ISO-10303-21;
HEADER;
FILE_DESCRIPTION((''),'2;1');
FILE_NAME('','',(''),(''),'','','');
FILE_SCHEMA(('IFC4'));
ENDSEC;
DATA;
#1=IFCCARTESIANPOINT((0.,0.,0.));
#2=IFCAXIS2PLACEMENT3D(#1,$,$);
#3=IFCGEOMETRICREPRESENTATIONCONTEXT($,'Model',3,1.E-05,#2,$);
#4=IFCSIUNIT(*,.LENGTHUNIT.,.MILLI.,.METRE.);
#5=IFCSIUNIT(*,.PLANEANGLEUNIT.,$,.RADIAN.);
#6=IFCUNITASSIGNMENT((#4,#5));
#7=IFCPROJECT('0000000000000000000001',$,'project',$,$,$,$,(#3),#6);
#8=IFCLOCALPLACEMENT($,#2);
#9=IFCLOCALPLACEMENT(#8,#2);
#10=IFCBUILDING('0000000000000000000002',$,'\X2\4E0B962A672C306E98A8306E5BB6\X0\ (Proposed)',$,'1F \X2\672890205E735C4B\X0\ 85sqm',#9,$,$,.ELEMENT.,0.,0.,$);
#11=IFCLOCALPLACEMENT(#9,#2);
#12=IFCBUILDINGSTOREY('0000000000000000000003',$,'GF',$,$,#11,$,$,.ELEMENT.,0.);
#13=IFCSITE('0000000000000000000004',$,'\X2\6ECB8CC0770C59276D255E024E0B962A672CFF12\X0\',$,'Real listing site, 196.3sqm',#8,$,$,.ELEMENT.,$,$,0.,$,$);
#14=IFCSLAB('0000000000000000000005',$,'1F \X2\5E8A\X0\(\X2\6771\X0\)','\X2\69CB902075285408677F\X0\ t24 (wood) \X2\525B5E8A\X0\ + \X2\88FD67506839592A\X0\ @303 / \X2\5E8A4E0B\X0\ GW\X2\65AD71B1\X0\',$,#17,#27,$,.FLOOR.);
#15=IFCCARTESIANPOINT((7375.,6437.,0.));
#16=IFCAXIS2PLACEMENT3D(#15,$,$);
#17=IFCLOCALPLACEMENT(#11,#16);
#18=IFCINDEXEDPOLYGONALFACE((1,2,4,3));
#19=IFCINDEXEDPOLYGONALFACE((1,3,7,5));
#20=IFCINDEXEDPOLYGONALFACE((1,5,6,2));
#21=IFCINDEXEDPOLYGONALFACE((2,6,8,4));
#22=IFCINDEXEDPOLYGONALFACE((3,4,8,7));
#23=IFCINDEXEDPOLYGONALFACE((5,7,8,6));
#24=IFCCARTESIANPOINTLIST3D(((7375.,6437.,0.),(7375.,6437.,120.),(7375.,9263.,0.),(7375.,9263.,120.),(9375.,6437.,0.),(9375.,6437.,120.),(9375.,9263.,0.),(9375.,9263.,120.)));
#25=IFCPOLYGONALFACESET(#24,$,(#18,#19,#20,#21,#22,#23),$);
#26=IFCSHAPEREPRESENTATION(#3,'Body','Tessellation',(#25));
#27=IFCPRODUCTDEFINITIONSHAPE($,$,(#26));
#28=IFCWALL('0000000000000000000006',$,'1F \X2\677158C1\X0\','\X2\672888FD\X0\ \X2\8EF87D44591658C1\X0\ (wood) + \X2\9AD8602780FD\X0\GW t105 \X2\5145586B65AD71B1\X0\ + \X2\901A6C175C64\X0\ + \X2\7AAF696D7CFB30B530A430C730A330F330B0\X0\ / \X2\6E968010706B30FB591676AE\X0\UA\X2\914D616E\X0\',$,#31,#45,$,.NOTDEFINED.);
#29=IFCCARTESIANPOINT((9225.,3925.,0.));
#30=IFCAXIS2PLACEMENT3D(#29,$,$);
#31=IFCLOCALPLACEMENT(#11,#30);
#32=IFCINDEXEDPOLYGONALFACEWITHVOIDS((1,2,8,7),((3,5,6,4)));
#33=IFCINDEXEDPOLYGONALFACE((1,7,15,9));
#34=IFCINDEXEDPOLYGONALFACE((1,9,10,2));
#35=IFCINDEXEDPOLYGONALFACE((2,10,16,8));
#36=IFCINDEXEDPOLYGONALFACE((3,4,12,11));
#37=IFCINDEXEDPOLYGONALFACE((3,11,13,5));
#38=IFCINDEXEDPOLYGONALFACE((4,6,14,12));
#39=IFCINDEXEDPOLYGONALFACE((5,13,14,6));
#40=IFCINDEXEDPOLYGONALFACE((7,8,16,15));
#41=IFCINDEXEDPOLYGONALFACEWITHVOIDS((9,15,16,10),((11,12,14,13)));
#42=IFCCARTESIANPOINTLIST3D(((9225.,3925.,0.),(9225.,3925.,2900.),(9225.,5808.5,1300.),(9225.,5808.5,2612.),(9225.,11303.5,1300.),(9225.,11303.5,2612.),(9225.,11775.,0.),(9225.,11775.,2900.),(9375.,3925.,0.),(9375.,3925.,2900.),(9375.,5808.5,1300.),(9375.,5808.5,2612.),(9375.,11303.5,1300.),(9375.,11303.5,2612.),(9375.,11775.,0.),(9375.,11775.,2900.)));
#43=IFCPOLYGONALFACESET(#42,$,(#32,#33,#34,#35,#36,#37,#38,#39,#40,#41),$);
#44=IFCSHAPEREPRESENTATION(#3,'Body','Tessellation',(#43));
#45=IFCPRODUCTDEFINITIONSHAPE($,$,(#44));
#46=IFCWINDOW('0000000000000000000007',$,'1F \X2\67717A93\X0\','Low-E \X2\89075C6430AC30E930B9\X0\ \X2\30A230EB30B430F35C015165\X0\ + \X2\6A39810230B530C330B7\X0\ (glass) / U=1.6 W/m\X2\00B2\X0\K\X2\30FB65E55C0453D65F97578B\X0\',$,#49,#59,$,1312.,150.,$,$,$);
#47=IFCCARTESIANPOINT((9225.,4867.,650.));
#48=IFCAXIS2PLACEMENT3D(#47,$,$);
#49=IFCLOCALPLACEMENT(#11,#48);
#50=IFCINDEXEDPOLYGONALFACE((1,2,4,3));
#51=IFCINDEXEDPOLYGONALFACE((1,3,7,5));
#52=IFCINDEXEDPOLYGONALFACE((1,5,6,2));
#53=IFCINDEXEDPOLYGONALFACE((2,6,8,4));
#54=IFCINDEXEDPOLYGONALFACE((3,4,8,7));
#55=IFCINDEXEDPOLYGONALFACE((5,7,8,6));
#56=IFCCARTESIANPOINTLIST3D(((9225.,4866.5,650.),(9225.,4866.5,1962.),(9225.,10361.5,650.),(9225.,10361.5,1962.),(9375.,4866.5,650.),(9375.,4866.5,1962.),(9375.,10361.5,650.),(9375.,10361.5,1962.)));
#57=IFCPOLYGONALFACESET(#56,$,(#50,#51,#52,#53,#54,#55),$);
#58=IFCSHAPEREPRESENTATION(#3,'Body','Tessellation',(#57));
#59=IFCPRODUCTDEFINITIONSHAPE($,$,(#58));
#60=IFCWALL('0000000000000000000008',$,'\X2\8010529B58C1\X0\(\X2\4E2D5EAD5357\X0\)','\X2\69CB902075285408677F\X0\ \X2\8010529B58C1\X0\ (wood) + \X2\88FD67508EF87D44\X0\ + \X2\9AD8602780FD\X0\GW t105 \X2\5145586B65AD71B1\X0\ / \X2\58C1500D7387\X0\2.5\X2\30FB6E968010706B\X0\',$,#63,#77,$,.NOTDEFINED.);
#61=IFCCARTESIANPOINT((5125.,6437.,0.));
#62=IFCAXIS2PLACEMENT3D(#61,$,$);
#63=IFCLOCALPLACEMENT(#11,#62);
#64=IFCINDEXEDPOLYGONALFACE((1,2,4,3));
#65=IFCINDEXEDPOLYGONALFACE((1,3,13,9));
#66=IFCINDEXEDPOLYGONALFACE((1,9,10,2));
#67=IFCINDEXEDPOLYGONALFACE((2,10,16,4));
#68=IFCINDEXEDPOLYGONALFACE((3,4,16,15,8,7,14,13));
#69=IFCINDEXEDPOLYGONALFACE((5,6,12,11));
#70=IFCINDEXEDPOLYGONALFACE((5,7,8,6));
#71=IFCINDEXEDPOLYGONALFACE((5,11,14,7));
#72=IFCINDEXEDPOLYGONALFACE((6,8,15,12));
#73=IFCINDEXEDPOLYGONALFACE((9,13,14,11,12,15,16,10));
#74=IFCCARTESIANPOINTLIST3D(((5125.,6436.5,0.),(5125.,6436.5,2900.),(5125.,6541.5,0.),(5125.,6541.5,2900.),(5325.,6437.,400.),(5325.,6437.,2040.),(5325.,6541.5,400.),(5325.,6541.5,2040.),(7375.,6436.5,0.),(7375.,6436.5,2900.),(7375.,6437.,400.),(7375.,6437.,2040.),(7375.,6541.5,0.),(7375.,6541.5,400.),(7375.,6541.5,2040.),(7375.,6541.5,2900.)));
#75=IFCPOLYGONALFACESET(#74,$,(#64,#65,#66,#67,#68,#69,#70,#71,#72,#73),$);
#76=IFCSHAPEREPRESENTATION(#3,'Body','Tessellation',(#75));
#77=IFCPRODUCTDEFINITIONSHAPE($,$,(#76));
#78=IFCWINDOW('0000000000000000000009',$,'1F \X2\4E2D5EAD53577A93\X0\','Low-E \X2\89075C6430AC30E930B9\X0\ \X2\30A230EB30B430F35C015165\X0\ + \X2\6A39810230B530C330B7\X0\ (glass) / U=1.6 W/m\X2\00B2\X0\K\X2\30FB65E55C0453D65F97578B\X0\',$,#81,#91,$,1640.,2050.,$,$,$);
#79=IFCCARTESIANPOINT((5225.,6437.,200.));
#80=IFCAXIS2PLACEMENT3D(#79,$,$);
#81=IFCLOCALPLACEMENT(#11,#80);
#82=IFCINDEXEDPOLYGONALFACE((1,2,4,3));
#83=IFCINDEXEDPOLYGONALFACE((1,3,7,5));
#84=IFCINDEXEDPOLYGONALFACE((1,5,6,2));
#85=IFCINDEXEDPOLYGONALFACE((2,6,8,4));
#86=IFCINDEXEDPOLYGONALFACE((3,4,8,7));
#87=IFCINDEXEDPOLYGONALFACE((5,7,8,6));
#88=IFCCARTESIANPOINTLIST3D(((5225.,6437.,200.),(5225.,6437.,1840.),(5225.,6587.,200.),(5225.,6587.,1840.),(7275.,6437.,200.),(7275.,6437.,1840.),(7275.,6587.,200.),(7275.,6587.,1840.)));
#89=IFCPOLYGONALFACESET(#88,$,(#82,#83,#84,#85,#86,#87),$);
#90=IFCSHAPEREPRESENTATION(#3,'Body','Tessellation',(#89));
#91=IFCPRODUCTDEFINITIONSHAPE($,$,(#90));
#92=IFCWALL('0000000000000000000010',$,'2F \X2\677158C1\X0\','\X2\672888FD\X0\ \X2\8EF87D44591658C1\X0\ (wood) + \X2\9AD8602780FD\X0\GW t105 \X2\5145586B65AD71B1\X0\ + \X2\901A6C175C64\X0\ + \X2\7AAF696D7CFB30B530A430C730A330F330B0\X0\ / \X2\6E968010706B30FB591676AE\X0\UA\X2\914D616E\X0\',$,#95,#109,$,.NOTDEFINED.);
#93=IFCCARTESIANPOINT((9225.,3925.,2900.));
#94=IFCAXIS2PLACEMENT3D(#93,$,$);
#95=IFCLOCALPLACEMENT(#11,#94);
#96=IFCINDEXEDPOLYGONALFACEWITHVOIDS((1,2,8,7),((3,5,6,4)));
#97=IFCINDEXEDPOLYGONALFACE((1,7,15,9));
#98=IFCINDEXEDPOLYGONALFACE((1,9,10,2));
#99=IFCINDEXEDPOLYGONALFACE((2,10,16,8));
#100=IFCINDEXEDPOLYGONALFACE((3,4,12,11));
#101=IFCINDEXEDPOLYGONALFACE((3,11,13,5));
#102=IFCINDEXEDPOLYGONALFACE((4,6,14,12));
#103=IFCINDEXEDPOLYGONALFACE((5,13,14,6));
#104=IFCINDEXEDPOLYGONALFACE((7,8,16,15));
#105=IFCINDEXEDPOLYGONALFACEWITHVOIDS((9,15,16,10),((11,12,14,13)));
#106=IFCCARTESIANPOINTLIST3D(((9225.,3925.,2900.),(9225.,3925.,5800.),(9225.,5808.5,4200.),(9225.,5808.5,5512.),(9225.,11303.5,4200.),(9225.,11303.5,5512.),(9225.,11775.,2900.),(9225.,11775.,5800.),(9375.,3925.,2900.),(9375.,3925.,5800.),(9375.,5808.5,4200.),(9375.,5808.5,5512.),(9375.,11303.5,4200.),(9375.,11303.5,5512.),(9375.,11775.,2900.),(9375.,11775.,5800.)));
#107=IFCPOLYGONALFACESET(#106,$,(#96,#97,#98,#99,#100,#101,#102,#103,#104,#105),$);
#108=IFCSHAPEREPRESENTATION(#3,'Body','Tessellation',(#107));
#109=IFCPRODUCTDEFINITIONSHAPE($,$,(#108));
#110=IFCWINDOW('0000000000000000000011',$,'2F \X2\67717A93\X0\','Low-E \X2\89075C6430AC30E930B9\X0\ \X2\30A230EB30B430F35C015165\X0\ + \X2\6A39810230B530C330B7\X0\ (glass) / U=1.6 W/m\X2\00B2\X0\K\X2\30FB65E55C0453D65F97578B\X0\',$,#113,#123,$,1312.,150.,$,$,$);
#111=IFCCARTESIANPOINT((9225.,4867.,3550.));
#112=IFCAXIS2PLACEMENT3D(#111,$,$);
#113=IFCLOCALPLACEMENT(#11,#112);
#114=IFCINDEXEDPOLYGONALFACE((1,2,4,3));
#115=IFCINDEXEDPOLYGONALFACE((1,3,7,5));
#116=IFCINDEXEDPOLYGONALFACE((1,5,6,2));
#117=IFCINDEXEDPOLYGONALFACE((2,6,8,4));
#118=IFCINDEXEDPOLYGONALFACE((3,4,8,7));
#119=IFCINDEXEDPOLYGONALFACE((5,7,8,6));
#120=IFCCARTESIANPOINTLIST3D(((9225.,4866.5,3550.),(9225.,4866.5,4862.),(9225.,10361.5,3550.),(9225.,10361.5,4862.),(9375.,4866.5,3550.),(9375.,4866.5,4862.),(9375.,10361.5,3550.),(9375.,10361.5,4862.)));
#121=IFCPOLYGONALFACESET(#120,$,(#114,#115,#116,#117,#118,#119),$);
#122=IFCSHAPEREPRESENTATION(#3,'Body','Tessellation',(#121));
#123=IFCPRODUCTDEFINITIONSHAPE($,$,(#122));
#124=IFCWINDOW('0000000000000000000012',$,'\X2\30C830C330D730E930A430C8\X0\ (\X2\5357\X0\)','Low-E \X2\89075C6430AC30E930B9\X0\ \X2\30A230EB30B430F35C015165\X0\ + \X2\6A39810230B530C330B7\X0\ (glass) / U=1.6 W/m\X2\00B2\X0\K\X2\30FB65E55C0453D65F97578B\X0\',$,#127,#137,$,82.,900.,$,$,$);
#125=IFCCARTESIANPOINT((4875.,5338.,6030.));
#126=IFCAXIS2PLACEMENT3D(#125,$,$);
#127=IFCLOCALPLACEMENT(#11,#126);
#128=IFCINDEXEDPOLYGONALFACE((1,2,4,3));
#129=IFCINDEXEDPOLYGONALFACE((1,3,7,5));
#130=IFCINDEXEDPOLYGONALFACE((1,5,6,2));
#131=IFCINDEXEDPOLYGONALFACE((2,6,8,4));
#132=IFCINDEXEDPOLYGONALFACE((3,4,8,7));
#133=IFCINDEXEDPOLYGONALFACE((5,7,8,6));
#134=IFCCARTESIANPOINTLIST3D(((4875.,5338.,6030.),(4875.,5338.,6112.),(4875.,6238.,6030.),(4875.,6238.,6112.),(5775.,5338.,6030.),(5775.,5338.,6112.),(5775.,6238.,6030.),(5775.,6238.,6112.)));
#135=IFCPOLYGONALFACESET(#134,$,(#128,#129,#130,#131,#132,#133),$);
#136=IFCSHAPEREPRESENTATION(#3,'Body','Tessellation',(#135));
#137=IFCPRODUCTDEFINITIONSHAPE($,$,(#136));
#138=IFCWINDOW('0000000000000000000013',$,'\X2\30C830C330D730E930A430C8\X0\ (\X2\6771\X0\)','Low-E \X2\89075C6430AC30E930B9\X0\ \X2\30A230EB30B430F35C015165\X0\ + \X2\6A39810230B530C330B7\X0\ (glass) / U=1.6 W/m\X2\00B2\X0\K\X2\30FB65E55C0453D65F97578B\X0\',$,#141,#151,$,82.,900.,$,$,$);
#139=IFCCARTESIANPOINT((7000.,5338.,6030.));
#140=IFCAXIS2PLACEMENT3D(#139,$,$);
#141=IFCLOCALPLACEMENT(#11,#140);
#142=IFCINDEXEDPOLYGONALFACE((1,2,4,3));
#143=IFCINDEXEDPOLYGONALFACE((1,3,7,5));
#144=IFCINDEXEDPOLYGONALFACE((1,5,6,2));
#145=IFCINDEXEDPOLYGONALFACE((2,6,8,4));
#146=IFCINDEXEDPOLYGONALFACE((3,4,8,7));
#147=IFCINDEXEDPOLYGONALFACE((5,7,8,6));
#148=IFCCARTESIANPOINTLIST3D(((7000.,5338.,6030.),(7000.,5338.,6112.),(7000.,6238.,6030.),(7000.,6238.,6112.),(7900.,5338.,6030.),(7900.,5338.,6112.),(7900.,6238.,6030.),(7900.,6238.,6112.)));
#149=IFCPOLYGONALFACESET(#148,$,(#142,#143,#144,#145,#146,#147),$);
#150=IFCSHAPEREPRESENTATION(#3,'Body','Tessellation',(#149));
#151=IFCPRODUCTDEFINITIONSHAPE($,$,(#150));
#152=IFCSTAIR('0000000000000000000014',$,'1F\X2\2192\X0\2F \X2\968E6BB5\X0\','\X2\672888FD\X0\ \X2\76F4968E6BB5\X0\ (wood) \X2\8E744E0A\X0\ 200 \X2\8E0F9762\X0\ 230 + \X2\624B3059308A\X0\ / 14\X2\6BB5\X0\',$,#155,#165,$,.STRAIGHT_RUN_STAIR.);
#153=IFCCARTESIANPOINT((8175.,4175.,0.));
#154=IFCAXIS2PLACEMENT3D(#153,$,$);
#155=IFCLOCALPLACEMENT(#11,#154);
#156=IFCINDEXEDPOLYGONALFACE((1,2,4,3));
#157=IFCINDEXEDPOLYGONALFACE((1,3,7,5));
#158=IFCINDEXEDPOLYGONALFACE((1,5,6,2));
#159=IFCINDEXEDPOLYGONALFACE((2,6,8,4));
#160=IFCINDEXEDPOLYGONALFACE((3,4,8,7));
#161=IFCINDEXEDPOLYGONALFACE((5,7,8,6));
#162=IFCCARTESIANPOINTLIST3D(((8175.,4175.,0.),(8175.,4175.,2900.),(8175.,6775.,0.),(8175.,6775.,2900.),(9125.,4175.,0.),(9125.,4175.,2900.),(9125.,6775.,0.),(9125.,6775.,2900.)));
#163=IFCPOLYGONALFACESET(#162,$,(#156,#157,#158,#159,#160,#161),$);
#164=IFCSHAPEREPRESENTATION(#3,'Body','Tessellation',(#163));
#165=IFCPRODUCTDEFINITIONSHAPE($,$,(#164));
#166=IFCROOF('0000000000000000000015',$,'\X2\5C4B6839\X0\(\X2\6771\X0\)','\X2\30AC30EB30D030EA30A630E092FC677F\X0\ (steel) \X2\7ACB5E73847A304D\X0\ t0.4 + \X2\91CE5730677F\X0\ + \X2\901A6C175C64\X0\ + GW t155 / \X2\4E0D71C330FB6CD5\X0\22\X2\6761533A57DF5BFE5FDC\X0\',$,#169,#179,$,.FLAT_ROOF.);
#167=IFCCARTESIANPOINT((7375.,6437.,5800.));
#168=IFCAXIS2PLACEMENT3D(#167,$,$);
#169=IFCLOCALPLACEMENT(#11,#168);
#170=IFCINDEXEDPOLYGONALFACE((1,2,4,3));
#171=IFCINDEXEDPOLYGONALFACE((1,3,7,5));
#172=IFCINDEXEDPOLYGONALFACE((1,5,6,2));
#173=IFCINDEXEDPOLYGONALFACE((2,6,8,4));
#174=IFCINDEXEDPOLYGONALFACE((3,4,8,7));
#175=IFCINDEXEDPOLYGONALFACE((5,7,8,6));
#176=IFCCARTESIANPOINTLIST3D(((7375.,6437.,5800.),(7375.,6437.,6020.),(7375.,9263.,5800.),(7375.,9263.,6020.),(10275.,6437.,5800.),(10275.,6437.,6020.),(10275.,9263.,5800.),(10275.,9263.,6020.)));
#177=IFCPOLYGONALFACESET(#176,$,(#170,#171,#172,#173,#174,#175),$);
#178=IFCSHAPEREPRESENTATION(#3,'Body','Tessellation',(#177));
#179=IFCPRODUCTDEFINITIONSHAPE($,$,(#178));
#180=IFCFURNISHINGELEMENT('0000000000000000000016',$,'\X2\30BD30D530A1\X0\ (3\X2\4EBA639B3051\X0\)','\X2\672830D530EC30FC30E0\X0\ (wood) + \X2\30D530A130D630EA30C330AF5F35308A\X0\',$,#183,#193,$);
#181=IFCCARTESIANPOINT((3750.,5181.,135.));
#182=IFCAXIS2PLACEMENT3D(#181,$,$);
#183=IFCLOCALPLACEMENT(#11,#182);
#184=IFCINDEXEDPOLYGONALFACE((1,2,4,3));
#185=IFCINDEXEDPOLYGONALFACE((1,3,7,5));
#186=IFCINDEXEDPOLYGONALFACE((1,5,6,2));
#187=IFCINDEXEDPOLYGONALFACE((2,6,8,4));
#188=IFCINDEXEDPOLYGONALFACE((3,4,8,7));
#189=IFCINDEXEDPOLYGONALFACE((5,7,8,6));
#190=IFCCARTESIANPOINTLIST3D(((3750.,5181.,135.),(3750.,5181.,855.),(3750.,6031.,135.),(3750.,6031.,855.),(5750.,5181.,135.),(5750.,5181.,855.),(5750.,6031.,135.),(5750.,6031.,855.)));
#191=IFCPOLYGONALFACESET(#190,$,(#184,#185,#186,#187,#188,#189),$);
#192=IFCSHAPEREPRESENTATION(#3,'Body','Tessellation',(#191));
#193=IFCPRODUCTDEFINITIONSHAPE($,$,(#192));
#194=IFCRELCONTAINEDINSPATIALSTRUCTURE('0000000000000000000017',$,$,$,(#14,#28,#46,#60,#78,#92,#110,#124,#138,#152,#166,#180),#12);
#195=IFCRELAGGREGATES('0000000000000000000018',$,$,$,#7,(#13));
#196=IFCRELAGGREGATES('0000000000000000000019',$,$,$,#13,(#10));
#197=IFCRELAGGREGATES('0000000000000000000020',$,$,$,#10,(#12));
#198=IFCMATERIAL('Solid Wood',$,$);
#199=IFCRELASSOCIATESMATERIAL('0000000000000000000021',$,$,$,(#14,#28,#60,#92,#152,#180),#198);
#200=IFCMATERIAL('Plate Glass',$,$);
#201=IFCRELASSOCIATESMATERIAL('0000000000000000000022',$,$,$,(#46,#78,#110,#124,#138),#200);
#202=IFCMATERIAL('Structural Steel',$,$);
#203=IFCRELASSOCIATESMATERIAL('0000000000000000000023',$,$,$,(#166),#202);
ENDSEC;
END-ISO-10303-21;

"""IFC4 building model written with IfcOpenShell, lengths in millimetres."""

from ifc_helpers import new_model, si_unit, frame, frame_2d, origin, place, context, project, spatial, rectangle, extrude, material, element, fill, save


model = new_model("IFC4")

# Units and contexts
model_context = context("Model", 3, precision=1e-05, world=origin())
ifc_project = project(units=[si_unit("LENGTHUNIT", "METRE", prefix="MILLI"), si_unit("PLANEANGLEUNIT", "RADIAN")], contexts=[model_context])

# Site, building, storey
site_placement = place(None, origin())
site = spatial("IfcSite", under=ifc_project, at=site_placement, Name="滋賀県大津市下阪本２", ObjectType="Real listing site, 196.3sqm", CompositionType="ELEMENT", RefElevation=0.0)
building_placement = place(site_placement, origin())
building = spatial("IfcBuilding", under=site, at=building_placement, Name="下阪本の風の家 (Proposed)", ObjectType="1F 木造平屋 85sqm", CompositionType="ELEMENT", ElevationOfRefHeight=0.0, ElevationOfTerrain=0.0)
storey_placement = place(building_placement, origin())
storey = spatial("IfcBuildingStorey", under=building, at=storey_placement, Name="GF", CompositionType="ELEMENT", Elevation=0.0)

# Slab
ifc_material_1 = material(Name="Solid Wood")
slab_placement = place(storey_placement, frame((7375.0, 6437.0, 0.0)))
element("IfcSlab", 1, at=slab_placement, inside=storey, material=ifc_material_1, Name="1F 床(東)", Description="構造用合板 t24 (wood) 剛床 + 製材根太 @303 / 床下 GW断熱", PredefinedType="FLOOR", context=model_context, shape_type="SweptSolid", body=[
    extrude(rectangle(XDim=2000.0, YDim=2826.0, at=frame_2d((1000.0, 1413.0))), frame((7375.0, 6437.0, 0.0)), (0.0, 0.0, 1.0), 120.0),
])

# Walls, openings, windows
wall_1_placement = place(storey_placement, frame((9225.0, 3925.0, 0.0)))
wall_1 = element("IfcWall", 2, at=wall_1_placement, inside=storey, material=ifc_material_1, Name="1F 東壁", Description="木製 軸組外壁 (wood) + 高性能GW t105 充填断熱 + 通気層 + 窯業系サイディング / 準耐火・外皮UA配慮", PredefinedType="NOTDEFINED", context=model_context, shape_type="SweptSolid", body=[
    extrude(rectangle(XDim=150.0, YDim=7850.0, at=frame_2d((75.0, 3925.0))), frame((9225.0, 3925.0, 0.0)), (0.0, 0.0, 1.0), 2900.0),
])
opening_1_placement = place(storey_placement, frame((9225.0, 4867.0, 650.0)))
opening_1 = element("IfcOpeningElement", 3, at=opening_1_placement, cuts=wall_1, PredefinedType="NOTDEFINED", context=model_context, shape_type="SweptSolid", body=[
    extrude(rectangle(XDim=150.0, YDim=5495.0, at=frame_2d((75.0, 2747.0))), frame((9225.0, 4867.0, 650.0)), (0.0, 0.0, 1.0), 1312.0),
])
ifc_material_2 = material(Name="Plate Glass")
window_1_placement = place(storey_placement, frame((9225.0, 4867.0, 650.0)))
window_1 = element("IfcWindow", 4, at=window_1_placement, inside=storey, material=ifc_material_2, Name="1F 東窓", Description="Low-E 複層ガラス アルゴン封入 + 樹脂サッシ (glass) / U=1.6 W/m²K・日射取得型", OverallHeight=1312.0, OverallWidth=150.0, context=model_context, shape_type="SweptSolid", body=[
    extrude(rectangle(XDim=150.0, YDim=5495.0, at=frame_2d((75.0, 2747.0))), frame((9225.0, 4867.0, 650.0)), (0.0, 0.0, 1.0), 1312.0),
])
fill(opening_1, window_1)
wall_2_placement = place(storey_placement, frame((5125.0, 6437.0, 0.0)))
wall_2 = element("IfcWall", 5, at=wall_2_placement, inside=storey, material=ifc_material_1, Name="耐力壁(中庭南)", Description="構造用合板 耐力壁 (wood) + 製材軸組 + 高性能GW t105 充填断熱 / 壁倍率2.5・準耐火", PredefinedType="NOTDEFINED", context=model_context, shape_type="SweptSolid", body=[
    extrude(rectangle(XDim=2250.0, YDim=105.0, at=frame_2d((1125.0, 52.0))), frame((5125.0, 6437.0, 0.0)), (0.0, 0.0, 1.0), 2900.0),
])
opening_2_placement = place(storey_placement, frame((5225.0, 6437.0, 200.0)))
opening_2 = element("IfcOpeningElement", 6, at=opening_2_placement, cuts=wall_2, PredefinedType="NOTDEFINED", context=model_context, shape_type="SweptSolid", body=[
    extrude(rectangle(XDim=2050.0, YDim=150.0, at=frame_2d((1025.0, 75.0))), frame((5225.0, 6437.0, 200.0)), (0.0, 0.0, 1.0), 1640.0),
])
window_2_placement = place(storey_placement, frame((5225.0, 6437.0, 200.0)))
window_2 = element("IfcWindow", 7, at=window_2_placement, inside=storey, material=ifc_material_2, Name="1F 中庭南窓", Description="Low-E 複層ガラス アルゴン封入 + 樹脂サッシ (glass) / U=1.6 W/m²K・日射取得型", OverallHeight=1640.0, OverallWidth=2050.0, context=model_context, shape_type="SweptSolid", body=[
    extrude(rectangle(XDim=2050.0, YDim=150.0, at=frame_2d((1025.0, 75.0))), frame((5225.0, 6437.0, 200.0)), (0.0, 0.0, 1.0), 1640.0),
])
fill(opening_2, window_2)

# Wall, opening, window
wall_3_placement = place(storey_placement, frame((9225.0, 3925.0, 2900.0)))
wall_3 = element("IfcWall", 8, at=wall_3_placement, inside=storey, material=ifc_material_1, Name="2F 東壁", Description="木製 軸組外壁 (wood) + 高性能GW t105 充填断熱 + 通気層 + 窯業系サイディング / 準耐火・外皮UA配慮", PredefinedType="NOTDEFINED", context=model_context, shape_type="SweptSolid", body=[
    extrude(rectangle(XDim=150.0, YDim=7850.0, at=frame_2d((75.0, 3925.0))), frame((9225.0, 3925.0, 2900.0)), (0.0, 0.0, 1.0), 2900.0),
])
opening_3_placement = place(storey_placement, frame((9225.0, 4867.0, 3550.0)))
opening_3 = element("IfcOpeningElement", 9, at=opening_3_placement, cuts=wall_3, PredefinedType="NOTDEFINED", context=model_context, shape_type="SweptSolid", body=[
    extrude(rectangle(XDim=150.0, YDim=5495.0, at=frame_2d((75.0, 2747.0))), frame((9225.0, 4867.0, 3550.0)), (0.0, 0.0, 1.0), 1312.0),
])
window_3_placement = place(storey_placement, frame((9225.0, 4867.0, 3550.0)))
window_3 = element("IfcWindow", 10, at=window_3_placement, inside=storey, material=ifc_material_2, Name="2F 東窓", Description="Low-E 複層ガラス アルゴン封入 + 樹脂サッシ (glass) / U=1.6 W/m²K・日射取得型", OverallHeight=1312.0, OverallWidth=150.0, context=model_context, shape_type="SweptSolid", body=[
    extrude(rectangle(XDim=150.0, YDim=5495.0, at=frame_2d((75.0, 2747.0))), frame((9225.0, 4867.0, 3550.0)), (0.0, 0.0, 1.0), 1312.0),
])
fill(opening_3, window_3)

# Windows
window_4_placement = place(storey_placement, frame((4875.0, 5338.0, 6030.0)))
element("IfcWindow", 11, at=window_4_placement, inside=storey, material=ifc_material_2, Name="トップライト (南)", Description="Low-E 複層ガラス アルゴン封入 + 樹脂サッシ (glass) / U=1.6 W/m²K・日射取得型", OverallHeight=82.0, OverallWidth=900.0, context=model_context, shape_type="SweptSolid", body=[
    extrude(rectangle(XDim=900.0, YDim=900.0, at=frame_2d((450.0, 450.0))), frame((4875.0, 5338.0, 6030.0)), (0.0, 0.0, 1.0), 82.0),
])
window_5_placement = place(storey_placement, frame((7000.0, 5338.0, 6030.0)))
element("IfcWindow", 12, at=window_5_placement, inside=storey, material=ifc_material_2, Name="トップライト (東)", Description="Low-E 複層ガラス アルゴン封入 + 樹脂サッシ (glass) / U=1.6 W/m²K・日射取得型", OverallHeight=82.0, OverallWidth=900.0, context=model_context, shape_type="SweptSolid", body=[
    extrude(rectangle(XDim=900.0, YDim=900.0, at=frame_2d((450.0, 450.0))), frame((7000.0, 5338.0, 6030.0)), (0.0, 0.0, 1.0), 82.0),
])

# Stair
stair_placement = place(storey_placement, frame((8175.0, 4175.0, 0.0)))
element("IfcStair", 13, at=stair_placement, inside=storey, material=ifc_material_1, Name="1F→2F 階段", Description="木製 直階段 (wood) 蹴上 200 踏面 230 + 手すり / 14段", PredefinedType="STRAIGHT_RUN_STAIR", context=model_context, shape_type="SweptSolid", body=[
    extrude(rectangle(XDim=950.0, YDim=2600.0, at=frame_2d((475.0, 1300.0))), frame((8175.0, 4175.0, 0.0)), (0.0, 0.0, 1.0), 2900.0),
])

# Roof
ifc_material_3 = material(Name="Structural Steel")
roof_placement = place(storey_placement, frame((7375.0, 6437.0, 5800.0)))
element("IfcRoof", 14, at=roof_placement, inside=storey, material=ifc_material_3, Name="屋根(東)", Description="ガルバリウム鋼板 (steel) 立平葺き t0.4 + 野地板 + 通気層 + GW t155 / 不燃・法22条区域対応", PredefinedType="FLAT_ROOF", context=model_context, shape_type="SweptSolid", body=[
    extrude(rectangle(XDim=2900.0, YDim=2826.0, at=frame_2d((1450.0, 1413.0))), frame((7375.0, 6437.0, 5800.0)), (0.0, 0.0, 1.0), 220.0),
])

# Furnishing element
furnishing_1_placement = place(storey_placement, frame((3750.0, 5181.0, 135.0)))
element("IfcFurnishingElement", 15, at=furnishing_1_placement, inside=storey, material=ifc_material_1, Name="ソファ (3人掛け)", Description="木フレーム (wood) + ファブリック張り", context=model_context, shape_type="SweptSolid", body=[
    extrude(rectangle(XDim=2000.0, YDim=850.0, at=frame_2d((1000.0, 425.0))), frame((3750.0, 5181.0, 135.0)), (0.0, 0.0, 1.0), 720.0),
])

save(model, "model.ifc")
